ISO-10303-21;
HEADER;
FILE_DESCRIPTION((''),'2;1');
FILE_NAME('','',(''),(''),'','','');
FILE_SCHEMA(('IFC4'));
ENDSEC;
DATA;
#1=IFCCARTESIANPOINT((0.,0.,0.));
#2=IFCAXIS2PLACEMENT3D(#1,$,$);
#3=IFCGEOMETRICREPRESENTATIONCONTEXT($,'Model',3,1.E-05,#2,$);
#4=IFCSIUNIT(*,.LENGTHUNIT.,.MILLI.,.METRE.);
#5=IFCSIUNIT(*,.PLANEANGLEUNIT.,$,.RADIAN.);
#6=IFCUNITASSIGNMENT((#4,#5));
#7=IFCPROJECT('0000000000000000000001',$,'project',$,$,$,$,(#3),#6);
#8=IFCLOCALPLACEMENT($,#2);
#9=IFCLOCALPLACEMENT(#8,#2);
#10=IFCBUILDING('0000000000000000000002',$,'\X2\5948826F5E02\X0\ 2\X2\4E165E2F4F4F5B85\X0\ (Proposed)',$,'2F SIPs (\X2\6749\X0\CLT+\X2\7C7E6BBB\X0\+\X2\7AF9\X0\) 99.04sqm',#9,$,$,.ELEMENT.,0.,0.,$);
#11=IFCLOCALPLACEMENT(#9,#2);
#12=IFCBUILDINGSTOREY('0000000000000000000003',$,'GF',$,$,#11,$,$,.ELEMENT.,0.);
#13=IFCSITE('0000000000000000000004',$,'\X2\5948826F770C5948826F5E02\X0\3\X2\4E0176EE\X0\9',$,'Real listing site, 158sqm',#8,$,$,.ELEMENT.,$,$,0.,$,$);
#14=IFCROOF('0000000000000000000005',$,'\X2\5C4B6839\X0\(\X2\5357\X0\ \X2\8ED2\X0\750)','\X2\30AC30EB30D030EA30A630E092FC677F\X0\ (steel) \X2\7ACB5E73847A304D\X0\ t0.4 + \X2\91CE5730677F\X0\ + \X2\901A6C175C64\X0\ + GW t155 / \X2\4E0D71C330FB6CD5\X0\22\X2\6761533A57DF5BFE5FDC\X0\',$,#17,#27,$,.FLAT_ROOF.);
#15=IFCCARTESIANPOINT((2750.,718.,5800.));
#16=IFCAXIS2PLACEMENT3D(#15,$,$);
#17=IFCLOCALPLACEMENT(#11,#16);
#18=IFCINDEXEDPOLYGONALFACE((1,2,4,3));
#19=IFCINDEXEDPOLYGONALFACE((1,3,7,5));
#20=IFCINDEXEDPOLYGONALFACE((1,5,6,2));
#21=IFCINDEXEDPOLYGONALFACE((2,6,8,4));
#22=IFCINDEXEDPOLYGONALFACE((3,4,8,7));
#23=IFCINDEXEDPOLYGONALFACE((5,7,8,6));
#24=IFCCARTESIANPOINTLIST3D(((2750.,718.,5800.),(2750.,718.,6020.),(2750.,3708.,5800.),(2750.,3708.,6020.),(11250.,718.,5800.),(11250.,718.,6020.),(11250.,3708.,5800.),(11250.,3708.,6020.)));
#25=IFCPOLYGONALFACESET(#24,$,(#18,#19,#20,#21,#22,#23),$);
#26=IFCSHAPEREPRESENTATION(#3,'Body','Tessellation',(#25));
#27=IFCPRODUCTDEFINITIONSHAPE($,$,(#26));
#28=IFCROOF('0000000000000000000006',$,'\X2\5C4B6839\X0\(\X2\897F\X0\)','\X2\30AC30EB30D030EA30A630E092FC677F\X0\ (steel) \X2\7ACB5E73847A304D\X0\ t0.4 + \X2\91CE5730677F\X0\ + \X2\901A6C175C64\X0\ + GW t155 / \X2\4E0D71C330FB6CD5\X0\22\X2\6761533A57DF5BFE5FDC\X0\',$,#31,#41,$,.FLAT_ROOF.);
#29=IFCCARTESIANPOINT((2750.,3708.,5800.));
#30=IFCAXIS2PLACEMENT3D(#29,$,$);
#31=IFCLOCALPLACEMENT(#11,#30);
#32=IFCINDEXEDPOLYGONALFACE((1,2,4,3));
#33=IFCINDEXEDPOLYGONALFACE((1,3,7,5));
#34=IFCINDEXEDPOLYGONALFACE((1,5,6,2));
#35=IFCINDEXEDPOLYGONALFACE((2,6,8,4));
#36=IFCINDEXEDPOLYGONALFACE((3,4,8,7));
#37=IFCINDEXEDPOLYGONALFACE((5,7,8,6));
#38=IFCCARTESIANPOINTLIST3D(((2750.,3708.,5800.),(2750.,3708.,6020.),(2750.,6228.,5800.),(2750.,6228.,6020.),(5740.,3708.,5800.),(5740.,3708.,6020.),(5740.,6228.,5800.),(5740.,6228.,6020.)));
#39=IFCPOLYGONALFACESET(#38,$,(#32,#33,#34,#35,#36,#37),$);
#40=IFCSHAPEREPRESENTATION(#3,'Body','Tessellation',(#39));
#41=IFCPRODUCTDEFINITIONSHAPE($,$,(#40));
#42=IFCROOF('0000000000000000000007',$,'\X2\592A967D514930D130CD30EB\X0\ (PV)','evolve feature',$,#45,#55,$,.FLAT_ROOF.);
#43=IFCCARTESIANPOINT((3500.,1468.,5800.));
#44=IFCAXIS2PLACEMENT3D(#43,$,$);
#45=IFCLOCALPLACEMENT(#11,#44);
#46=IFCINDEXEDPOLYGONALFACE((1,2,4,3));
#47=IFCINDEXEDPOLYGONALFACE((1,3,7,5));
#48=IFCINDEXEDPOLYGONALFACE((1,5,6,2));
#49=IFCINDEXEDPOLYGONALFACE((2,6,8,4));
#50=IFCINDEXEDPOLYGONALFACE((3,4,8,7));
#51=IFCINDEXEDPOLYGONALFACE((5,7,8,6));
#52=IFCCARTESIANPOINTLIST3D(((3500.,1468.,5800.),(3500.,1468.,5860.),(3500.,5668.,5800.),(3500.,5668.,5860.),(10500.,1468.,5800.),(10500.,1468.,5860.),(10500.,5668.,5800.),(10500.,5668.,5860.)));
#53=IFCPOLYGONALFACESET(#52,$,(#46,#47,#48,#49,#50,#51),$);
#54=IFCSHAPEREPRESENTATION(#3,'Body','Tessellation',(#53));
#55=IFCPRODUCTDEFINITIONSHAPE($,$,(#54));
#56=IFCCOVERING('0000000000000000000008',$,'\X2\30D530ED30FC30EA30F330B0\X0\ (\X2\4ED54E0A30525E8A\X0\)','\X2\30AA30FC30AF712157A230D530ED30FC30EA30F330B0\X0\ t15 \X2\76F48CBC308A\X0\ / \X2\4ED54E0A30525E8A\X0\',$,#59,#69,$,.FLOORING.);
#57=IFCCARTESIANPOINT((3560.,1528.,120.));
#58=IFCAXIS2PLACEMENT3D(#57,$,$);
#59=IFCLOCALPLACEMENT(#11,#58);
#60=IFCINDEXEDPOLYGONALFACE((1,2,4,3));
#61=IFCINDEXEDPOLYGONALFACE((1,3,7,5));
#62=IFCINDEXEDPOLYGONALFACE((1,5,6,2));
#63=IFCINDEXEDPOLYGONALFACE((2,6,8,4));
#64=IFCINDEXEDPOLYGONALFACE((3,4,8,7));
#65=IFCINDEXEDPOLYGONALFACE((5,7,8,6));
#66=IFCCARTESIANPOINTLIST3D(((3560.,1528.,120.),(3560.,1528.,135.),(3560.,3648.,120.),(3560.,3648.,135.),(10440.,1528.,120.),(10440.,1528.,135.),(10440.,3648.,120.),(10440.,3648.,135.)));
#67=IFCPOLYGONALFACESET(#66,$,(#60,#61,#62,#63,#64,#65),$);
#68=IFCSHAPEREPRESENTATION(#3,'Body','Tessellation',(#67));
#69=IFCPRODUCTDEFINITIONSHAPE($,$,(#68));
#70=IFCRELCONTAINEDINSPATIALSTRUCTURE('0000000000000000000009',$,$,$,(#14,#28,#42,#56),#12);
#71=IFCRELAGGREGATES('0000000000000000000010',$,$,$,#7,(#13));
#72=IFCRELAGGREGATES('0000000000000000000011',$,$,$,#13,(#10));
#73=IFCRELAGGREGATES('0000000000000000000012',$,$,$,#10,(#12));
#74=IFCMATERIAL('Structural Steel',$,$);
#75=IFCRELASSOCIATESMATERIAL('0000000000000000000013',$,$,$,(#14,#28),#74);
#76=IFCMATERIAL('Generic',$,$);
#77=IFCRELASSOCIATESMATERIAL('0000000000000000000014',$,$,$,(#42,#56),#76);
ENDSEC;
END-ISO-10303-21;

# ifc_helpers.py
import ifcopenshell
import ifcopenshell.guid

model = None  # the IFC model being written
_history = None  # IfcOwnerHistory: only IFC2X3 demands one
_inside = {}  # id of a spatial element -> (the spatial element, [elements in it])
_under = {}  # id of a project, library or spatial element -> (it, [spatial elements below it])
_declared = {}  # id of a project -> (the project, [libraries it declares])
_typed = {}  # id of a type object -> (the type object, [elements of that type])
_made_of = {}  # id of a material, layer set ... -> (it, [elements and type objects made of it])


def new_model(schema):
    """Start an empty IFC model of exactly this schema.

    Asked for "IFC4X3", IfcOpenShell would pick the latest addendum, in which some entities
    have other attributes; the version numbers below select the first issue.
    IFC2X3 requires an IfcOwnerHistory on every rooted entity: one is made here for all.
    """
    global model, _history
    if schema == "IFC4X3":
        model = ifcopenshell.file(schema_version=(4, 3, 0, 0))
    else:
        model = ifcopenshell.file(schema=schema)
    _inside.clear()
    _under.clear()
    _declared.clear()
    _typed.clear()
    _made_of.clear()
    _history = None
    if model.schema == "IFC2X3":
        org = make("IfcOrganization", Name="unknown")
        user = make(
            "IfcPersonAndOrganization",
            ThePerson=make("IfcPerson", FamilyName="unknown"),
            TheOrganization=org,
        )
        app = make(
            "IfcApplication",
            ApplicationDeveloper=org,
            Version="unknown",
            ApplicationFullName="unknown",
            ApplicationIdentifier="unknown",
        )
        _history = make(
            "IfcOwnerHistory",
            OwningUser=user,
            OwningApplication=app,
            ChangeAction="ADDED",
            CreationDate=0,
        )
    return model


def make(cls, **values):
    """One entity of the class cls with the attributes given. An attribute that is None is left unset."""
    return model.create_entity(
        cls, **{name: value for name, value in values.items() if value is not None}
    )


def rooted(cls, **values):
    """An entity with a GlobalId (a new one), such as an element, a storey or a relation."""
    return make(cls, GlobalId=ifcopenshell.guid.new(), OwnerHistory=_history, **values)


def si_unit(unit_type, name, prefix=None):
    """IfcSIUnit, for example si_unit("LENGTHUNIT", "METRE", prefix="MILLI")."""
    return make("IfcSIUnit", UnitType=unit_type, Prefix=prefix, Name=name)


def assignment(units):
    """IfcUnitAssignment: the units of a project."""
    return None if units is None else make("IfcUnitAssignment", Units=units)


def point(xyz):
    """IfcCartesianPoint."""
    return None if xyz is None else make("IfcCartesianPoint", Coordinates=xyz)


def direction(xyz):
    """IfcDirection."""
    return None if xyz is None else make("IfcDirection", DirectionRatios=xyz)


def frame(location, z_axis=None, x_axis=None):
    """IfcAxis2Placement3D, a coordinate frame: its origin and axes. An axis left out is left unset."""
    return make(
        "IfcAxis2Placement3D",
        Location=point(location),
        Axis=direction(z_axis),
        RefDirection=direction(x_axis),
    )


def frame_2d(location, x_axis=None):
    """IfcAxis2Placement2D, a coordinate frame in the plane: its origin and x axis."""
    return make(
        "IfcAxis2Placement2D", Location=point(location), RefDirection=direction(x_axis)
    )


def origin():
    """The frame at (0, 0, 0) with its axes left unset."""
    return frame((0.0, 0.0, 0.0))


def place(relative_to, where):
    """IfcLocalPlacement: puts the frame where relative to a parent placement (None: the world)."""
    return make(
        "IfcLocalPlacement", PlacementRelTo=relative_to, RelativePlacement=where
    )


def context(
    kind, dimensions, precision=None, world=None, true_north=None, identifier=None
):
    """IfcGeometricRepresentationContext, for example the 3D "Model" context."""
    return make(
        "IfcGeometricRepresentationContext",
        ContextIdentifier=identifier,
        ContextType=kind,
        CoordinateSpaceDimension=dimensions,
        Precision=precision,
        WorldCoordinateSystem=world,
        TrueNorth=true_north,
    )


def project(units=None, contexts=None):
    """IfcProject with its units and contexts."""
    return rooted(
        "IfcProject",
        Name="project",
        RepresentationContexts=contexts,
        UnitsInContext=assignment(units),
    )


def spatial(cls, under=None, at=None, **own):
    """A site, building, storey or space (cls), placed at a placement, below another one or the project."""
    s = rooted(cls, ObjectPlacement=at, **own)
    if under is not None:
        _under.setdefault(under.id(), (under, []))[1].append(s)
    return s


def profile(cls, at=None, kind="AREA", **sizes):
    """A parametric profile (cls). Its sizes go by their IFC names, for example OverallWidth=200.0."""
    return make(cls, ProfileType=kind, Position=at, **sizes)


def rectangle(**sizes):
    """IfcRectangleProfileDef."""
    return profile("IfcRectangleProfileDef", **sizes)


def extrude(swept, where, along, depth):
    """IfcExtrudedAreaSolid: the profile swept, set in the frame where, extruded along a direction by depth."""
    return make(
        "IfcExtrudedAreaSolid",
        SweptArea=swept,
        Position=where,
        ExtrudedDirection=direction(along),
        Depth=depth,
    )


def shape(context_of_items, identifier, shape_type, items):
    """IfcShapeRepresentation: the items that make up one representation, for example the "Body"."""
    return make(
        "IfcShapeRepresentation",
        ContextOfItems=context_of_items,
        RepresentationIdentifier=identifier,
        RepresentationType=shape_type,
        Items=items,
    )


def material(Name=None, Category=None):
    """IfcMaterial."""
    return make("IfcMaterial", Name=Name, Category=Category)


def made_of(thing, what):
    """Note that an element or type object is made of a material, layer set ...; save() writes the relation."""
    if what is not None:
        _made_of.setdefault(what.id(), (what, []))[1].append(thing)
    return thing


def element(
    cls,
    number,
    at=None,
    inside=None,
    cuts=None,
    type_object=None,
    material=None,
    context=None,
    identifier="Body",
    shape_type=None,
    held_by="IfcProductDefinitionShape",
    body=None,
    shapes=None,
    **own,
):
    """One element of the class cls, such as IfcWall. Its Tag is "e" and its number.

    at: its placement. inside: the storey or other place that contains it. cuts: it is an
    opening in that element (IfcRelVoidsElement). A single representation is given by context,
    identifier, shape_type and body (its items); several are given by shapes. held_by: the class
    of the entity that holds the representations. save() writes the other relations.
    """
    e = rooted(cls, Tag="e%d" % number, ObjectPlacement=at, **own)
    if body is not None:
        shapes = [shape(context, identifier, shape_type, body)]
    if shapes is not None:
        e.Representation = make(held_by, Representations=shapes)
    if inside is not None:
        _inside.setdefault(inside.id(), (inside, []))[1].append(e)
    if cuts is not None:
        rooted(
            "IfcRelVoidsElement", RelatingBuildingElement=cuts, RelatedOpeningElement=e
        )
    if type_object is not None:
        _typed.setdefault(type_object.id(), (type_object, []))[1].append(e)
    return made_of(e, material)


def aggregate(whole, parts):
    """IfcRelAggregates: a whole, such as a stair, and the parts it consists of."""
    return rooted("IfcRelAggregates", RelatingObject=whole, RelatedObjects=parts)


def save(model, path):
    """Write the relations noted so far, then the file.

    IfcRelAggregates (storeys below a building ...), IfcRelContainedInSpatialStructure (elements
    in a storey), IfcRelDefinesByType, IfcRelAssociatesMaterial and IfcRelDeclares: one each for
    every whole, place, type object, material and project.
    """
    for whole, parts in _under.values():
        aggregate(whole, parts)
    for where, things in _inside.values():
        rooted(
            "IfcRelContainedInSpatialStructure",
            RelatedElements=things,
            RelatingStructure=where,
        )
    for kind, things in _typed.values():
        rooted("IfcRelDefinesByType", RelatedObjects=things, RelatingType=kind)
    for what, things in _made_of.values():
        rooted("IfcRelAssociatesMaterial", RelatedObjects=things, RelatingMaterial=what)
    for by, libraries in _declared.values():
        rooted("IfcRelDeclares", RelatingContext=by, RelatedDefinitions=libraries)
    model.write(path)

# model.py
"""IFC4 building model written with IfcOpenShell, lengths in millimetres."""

from ifc_helpers import new_model, si_unit, frame, frame_2d, origin, place, context, project, spatial, rectangle, extrude, material, element, save


model = new_model("IFC4")

# Units and contexts
model_context = context("Model", 3, precision=1e-05, world=origin())
ifc_project = project(units=[si_unit("LENGTHUNIT", "METRE", prefix="MILLI"), si_unit("PLANEANGLEUNIT", "RADIAN")], contexts=[model_context])

# Site, building, storey
site_placement = place(None, origin())
site = spatial("IfcSite", under=ifc_project, at=site_placement, Name="奈良県奈良市3丁目9", ObjectType="Real listing site, 158sqm", CompositionType="ELEMENT", RefElevation=0.0)
building_placement = place(site_placement, origin())
building = spatial("IfcBuilding", under=site, at=building_placement, Name="奈良市 2世帯住宅 (Proposed)", ObjectType="2F SIPs (杉CLT+籾殻+竹) 99.04sqm", CompositionType="ELEMENT", ElevationOfRefHeight=0.0, ElevationOfTerrain=0.0)
storey_placement = place(building_placement, origin())
storey = spatial("IfcBuildingStorey", under=building, at=storey_placement, Name="GF", CompositionType="ELEMENT", Elevation=0.0)

# Shared definitions
ifc_material_1 = material(Name="Generic")

# Roofs
ifc_material_2 = material(Name="Structural Steel")
roof_1_placement = place(storey_placement, frame((2750.0, 718.0, 5800.0)))
element("IfcRoof", 1, at=roof_1_placement, inside=storey, material=ifc_material_2, Name="屋根(南 軒750)", Description="ガルバリウム鋼板 (steel) 立平葺き t0.4 + 野地板 + 通気層 + GW t155 / 不燃・法22条区域対応", PredefinedType="FLAT_ROOF", context=model_context, shape_type="SweptSolid", body=[
    extrude(rectangle(XDim=8500.0, YDim=2990.0, at=frame_2d((4250.0, 1495.0))), frame((2750.0, 718.0, 5800.0)), (0.0, 0.0, 1.0), 220.0),
])
roof_2_placement = place(storey_placement, frame((2750.0, 3708.0, 5800.0)))
element("IfcRoof", 2, at=roof_2_placement, inside=storey, material=ifc_material_2, Name="屋根(西)", Description="ガルバリウム鋼板 (steel) 立平葺き t0.4 + 野地板 + 通気層 + GW t155 / 不燃・法22条区域対応", PredefinedType="FLAT_ROOF", context=model_context, shape_type="SweptSolid", body=[
    extrude(rectangle(XDim=2990.0, YDim=2520.0, at=frame_2d((1495.0, 1260.0))), frame((2750.0, 3708.0, 5800.0)), (0.0, 0.0, 1.0), 220.0),
])
roof_3_placement = place(storey_placement, frame((3500.0, 1468.0, 5800.0)))
element("IfcRoof", 3, at=roof_3_placement, inside=storey, material=ifc_material_1, Name="太陽光パネル (PV)", Description="evolve feature", PredefinedType="FLAT_ROOF", context=model_context, shape_type="SweptSolid", body=[
    extrude(rectangle(XDim=7000.0, YDim=4200.0, at=frame_2d((3500.0, 2100.0))), frame((3500.0, 1468.0, 5800.0)), (0.0, 0.0, 1.0), 60.0),
])

# Covering
covering_placement = place(storey_placement, frame((3560.0, 1528.0, 120.0)))
element("IfcCovering", 4, at=covering_placement, inside=storey, material=ifc_material_1, Name="フローリング (仕上げ床)", Description="オーク無垢フローリング t15 直貼り / 仕上げ床", PredefinedType="FLOORING", context=model_context, shape_type="SweptSolid", body=[
    extrude(rectangle(XDim=6880.0, YDim=2120.0, at=frame_2d((3440.0, 1060.0))), frame((3560.0, 1528.0, 120.0)), (0.0, 0.0, 1.0), 15.0),
])

save(model, "model.ifc")
